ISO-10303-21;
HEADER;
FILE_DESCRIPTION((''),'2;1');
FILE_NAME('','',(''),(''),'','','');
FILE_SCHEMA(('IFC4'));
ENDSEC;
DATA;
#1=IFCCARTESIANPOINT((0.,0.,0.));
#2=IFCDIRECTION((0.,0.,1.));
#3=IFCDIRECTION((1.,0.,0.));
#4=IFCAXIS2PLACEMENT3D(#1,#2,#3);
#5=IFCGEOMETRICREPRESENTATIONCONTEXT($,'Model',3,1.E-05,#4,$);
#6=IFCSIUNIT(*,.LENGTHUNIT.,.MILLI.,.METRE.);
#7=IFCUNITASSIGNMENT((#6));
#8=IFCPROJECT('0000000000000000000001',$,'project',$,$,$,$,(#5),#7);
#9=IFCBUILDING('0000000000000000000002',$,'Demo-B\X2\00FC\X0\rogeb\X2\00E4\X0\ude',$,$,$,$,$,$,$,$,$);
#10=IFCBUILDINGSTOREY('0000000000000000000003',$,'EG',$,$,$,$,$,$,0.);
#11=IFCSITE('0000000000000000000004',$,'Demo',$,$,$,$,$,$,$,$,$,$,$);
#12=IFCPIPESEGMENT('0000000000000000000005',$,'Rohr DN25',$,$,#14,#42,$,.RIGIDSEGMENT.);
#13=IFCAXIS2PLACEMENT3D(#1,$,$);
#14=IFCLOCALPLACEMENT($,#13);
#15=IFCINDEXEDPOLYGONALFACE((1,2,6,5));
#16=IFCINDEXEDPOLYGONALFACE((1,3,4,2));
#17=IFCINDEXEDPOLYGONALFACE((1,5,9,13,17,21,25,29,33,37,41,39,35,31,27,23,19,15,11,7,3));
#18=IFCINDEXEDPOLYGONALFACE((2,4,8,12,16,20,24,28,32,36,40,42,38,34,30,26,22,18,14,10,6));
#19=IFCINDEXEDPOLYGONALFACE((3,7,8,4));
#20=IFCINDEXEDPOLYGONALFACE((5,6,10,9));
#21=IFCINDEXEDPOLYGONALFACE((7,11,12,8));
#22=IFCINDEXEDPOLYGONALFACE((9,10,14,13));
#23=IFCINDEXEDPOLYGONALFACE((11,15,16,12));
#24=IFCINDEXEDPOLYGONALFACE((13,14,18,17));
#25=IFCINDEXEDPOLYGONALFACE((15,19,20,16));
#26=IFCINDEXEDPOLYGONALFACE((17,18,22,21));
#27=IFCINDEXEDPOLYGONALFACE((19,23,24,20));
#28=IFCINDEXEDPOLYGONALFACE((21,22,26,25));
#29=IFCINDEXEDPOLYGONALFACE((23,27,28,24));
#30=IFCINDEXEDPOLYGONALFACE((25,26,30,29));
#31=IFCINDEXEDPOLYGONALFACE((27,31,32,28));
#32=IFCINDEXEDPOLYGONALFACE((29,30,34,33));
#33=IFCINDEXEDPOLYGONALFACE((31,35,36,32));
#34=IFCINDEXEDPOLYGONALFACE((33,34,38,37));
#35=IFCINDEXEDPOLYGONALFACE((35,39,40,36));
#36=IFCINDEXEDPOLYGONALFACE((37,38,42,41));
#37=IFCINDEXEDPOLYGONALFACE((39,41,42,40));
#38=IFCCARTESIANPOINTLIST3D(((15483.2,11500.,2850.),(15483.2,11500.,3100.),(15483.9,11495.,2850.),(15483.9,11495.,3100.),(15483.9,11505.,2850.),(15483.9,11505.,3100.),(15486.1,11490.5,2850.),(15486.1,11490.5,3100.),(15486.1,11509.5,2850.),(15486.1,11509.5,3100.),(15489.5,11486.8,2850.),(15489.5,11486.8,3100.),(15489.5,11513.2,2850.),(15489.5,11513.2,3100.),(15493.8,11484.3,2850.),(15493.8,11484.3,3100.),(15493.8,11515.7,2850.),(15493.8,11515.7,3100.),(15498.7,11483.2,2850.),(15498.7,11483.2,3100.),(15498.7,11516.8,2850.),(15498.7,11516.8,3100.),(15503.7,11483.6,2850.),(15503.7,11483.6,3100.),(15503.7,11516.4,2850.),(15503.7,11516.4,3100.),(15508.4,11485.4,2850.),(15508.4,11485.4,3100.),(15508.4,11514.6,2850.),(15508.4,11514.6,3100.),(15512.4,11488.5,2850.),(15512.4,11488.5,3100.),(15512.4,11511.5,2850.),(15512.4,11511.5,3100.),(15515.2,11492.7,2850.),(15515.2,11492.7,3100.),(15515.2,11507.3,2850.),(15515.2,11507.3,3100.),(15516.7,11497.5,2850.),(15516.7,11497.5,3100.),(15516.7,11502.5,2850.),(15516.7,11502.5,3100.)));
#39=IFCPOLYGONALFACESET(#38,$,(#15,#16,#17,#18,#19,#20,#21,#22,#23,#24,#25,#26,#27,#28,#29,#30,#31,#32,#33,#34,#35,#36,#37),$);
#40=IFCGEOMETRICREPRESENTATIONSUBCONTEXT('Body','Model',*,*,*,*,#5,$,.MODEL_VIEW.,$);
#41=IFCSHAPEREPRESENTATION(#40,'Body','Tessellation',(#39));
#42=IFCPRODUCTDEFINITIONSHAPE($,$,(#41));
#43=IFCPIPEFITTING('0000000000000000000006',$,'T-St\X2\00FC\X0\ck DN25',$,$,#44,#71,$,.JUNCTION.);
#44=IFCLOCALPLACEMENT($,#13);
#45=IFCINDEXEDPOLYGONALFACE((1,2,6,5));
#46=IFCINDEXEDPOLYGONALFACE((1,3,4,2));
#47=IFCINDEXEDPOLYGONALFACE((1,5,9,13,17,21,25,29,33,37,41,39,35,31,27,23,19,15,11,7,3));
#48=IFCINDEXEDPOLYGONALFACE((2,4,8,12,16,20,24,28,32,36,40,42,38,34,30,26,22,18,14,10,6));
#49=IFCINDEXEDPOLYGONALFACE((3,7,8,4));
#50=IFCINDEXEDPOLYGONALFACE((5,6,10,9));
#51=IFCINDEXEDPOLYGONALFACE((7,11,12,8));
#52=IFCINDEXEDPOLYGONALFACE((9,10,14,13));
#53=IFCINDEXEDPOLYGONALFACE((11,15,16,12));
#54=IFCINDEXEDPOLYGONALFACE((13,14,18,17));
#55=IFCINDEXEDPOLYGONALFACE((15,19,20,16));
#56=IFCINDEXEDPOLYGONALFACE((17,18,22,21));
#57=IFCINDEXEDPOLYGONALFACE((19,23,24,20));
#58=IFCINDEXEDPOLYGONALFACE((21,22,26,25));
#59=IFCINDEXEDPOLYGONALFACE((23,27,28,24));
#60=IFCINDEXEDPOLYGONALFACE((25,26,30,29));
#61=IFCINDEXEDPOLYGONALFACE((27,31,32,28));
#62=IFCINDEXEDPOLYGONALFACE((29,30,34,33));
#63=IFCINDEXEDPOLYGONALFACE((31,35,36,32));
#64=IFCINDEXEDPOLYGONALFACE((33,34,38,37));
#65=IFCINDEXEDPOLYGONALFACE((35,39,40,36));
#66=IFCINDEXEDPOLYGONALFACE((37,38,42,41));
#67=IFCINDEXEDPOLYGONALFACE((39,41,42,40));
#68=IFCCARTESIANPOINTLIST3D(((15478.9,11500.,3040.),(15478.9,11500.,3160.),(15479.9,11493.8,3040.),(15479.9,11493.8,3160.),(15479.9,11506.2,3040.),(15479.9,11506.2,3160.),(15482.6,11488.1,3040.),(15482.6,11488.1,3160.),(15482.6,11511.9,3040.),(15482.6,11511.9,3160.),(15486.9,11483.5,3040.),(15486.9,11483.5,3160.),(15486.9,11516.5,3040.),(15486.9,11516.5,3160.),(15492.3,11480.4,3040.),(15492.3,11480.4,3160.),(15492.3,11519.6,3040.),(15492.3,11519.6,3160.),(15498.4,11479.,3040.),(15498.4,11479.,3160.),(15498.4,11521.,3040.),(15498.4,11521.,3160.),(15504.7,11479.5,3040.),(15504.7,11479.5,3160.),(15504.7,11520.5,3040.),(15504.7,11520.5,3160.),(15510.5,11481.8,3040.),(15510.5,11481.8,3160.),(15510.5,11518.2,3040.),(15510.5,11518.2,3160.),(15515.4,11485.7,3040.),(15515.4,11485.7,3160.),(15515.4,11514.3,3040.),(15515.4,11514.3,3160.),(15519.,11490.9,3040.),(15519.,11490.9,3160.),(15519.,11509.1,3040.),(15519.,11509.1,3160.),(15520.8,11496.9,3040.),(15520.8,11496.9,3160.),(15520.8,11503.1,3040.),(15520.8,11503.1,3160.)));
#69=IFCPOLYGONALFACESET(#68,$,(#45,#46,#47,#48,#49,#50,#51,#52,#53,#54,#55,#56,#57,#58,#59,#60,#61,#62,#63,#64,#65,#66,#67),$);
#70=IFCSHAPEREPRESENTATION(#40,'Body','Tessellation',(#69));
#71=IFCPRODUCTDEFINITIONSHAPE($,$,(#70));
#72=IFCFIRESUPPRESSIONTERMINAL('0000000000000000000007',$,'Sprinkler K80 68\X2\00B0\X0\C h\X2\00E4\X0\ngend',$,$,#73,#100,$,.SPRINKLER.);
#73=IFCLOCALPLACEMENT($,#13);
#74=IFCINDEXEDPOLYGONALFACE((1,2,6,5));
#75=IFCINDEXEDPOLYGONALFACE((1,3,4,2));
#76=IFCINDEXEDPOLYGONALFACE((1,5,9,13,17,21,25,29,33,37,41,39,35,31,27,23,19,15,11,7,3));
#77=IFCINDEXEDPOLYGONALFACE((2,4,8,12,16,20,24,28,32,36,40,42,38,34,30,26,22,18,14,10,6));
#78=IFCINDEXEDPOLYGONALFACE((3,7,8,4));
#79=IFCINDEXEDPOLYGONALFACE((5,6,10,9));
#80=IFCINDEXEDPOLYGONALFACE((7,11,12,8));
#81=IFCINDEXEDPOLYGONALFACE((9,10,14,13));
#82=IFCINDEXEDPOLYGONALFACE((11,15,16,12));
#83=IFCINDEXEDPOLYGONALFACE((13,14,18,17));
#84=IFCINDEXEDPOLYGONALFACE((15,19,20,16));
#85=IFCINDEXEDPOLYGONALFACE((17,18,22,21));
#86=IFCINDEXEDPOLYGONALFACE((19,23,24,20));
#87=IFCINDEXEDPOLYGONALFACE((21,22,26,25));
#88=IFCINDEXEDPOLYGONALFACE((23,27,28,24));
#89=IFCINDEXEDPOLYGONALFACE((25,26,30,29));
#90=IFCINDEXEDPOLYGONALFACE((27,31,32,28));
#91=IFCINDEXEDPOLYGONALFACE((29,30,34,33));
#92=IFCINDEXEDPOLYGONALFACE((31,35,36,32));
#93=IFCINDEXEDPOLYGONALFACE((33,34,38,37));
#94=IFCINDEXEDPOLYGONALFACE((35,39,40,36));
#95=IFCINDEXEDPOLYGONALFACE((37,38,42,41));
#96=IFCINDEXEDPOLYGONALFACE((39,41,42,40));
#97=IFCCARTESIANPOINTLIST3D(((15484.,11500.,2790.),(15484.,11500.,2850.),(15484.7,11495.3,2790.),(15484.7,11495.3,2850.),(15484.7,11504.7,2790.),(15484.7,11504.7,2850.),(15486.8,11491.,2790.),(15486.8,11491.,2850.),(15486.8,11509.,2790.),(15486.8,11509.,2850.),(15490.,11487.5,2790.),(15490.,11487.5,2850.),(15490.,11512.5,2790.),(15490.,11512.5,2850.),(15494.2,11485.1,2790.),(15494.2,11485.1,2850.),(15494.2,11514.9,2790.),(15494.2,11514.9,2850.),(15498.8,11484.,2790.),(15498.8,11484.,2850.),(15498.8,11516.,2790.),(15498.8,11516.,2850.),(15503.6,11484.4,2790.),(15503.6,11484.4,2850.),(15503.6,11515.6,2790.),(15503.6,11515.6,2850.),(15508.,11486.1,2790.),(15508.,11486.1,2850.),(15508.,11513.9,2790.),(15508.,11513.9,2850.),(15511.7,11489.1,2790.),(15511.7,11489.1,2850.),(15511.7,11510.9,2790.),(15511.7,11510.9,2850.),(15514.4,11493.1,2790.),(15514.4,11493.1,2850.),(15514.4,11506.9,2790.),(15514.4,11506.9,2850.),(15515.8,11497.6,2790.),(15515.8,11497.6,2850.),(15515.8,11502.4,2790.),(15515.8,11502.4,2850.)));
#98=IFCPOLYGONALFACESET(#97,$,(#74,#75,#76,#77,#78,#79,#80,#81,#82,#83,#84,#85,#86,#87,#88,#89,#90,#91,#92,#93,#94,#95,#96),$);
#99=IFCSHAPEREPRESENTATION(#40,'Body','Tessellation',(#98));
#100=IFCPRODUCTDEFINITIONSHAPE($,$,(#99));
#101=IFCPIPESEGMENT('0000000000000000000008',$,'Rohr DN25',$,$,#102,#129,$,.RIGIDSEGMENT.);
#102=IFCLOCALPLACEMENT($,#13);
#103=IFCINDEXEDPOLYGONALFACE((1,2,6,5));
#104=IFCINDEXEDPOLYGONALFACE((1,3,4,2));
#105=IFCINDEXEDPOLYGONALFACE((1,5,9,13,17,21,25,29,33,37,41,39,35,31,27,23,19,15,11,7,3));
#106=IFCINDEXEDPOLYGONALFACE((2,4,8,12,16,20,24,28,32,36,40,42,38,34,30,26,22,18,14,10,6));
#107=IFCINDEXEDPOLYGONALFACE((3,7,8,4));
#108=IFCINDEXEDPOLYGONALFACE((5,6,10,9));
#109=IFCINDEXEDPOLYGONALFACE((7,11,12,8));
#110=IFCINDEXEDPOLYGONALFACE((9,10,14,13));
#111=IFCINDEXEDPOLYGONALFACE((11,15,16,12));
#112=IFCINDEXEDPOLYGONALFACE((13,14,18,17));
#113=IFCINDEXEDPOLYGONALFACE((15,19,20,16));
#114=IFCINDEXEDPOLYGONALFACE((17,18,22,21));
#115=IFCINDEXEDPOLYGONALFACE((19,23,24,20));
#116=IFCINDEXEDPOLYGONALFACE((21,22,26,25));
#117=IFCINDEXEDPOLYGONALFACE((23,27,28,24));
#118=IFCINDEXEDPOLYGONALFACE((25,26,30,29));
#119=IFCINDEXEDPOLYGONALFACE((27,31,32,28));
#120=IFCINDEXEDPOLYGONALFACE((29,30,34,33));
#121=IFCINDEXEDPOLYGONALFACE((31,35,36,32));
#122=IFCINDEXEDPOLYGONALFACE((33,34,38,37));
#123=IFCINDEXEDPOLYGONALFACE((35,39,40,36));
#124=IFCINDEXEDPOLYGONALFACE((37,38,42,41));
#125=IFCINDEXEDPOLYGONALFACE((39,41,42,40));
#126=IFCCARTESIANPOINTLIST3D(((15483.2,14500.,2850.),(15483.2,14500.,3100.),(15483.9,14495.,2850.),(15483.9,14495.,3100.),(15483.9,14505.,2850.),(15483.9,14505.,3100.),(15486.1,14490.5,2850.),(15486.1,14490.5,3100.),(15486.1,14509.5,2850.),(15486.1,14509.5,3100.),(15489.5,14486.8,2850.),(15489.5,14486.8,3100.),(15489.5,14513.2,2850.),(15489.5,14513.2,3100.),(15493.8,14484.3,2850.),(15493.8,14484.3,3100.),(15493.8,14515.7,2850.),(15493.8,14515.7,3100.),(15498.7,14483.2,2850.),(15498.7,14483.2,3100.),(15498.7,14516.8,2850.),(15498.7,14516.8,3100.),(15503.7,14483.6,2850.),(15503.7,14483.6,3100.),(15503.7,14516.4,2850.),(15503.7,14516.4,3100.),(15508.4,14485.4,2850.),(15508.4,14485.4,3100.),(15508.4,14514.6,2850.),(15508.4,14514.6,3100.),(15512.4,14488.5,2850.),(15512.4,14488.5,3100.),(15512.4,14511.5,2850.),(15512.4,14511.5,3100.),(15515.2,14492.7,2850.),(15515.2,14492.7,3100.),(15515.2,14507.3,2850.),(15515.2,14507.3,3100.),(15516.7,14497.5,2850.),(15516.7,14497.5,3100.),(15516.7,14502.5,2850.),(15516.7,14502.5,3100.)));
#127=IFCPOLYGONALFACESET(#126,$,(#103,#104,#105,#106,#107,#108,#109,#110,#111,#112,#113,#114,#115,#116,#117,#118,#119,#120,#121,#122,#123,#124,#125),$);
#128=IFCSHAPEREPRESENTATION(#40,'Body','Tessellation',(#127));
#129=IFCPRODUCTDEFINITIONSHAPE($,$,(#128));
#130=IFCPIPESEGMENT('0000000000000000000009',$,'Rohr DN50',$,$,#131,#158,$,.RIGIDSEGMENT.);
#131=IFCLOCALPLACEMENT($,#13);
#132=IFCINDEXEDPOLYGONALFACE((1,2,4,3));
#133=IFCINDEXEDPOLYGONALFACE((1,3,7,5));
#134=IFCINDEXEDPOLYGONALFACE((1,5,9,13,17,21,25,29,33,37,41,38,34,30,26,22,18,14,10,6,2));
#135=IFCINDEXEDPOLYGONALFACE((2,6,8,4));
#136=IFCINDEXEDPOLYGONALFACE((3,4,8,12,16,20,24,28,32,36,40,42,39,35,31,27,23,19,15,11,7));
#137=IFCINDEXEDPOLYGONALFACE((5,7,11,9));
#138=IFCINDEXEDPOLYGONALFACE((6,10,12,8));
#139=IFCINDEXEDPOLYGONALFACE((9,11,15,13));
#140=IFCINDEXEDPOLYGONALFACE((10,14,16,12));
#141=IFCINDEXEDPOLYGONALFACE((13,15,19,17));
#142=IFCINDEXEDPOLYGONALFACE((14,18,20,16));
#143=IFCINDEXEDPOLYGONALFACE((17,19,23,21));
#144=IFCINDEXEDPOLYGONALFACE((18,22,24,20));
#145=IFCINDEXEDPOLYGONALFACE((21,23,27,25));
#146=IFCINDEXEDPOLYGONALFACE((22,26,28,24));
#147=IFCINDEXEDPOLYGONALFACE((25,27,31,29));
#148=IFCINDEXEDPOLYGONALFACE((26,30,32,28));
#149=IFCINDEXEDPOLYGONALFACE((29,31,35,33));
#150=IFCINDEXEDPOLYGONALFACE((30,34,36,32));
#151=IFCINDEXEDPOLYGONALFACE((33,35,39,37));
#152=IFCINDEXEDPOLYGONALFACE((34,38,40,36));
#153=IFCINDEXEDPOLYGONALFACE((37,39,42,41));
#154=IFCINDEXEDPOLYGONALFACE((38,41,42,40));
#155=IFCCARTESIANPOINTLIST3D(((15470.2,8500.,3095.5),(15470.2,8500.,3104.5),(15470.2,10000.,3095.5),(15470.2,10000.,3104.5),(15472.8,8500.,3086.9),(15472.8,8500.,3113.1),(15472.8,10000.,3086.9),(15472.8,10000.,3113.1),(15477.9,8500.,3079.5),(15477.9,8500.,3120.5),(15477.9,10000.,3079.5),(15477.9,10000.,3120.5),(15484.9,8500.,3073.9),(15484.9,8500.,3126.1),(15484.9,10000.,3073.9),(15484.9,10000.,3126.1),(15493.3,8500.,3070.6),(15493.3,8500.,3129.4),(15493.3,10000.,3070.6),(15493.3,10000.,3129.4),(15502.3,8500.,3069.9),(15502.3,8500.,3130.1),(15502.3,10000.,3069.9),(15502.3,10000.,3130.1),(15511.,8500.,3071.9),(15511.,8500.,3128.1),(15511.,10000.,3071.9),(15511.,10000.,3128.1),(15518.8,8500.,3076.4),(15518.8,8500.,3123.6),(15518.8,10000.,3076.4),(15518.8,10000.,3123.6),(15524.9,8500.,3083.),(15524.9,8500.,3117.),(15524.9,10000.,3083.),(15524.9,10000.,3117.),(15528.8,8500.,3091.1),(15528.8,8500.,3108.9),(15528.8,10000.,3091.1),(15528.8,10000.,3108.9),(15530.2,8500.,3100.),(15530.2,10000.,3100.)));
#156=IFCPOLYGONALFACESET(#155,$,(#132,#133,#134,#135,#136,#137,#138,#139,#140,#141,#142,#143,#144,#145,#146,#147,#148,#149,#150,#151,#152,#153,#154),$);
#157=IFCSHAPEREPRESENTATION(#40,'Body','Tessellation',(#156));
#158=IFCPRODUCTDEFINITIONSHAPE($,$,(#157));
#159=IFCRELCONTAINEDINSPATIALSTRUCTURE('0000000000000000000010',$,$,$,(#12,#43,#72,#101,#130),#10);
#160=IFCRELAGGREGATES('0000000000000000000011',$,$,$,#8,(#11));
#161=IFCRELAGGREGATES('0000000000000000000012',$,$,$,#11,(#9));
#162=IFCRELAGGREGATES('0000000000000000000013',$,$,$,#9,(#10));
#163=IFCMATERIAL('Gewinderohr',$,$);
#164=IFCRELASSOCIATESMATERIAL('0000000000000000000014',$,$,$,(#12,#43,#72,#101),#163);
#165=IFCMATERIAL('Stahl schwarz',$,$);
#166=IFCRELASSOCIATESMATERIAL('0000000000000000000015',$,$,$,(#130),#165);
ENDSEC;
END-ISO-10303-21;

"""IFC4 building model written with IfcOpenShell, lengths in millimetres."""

from ifc_helpers import new_model, si_unit, frame, origin_with_axes, place, context, subcontext, project, spatial, circle, extrude, material, element, save


model = new_model("IFC4")

# Units and contexts
model_context = context("Model", 3, precision=1e-05, world=origin_with_axes())
body_context = subcontext(model_context, "Body", "Model", "MODEL_VIEW")
ifc_project = project(units=[si_unit("LENGTHUNIT", "METRE", prefix="MILLI")], contexts=[model_context])

# Site, building, storey
site = spatial("IfcSite", under=ifc_project, Name="Demo")
building = spatial("IfcBuilding", under=site, Name="Demo-Bürogebäude")
storey = spatial("IfcBuildingStorey", under=building, Name="EG", Elevation=0.0)

# Shared definitions
ifc_material_1 = material(Name="Stahl schwarz")

# Shared definitions
ifc_material_2 = material(Name="Gewinderohr")

# Pipe segment
pipe_segment_1_placement = place(None, frame((15500.0, 11500.0, 3100.0), z_axis=(0.0, 0.0, -1.0), x_axis=(-1.0, 0.0, 0.0)))
element("IfcPipeSegment", 1, at=pipe_segment_1_placement, inside=storey, material=ifc_material_2, Name="Rohr DN25", PredefinedType="RIGIDSEGMENT", context=body_context, shape_type="SweptSolid", body=[
    extrude(circle(Radius=16.9), origin_with_axes(), (0.0, 0.0, 1.0), 250.0),
])

# Pipe fitting
pipe_fitting_1_placement = place(None, frame((15500.0, 11500.0, 3160.0), z_axis=(0.0, 0.0, -1.0), x_axis=(-1.0, 0.0, 0.0)))
element("IfcPipeFitting", 2, at=pipe_fitting_1_placement, inside=storey, material=ifc_material_2, Name="T-Stück DN25", PredefinedType="JUNCTION", context=body_context, shape_type="SweptSolid", body=[
    extrude(circle(Radius=21.1), origin_with_axes(), (0.0, 0.0, 1.0), 120.0),
])

# Fire suppression terminal
fire_suppression_terminal_1_placement = place(None, frame((15500.0, 11500.0, 2850.0), z_axis=(0.0, 0.0, -1.0), x_axis=(-1.0, 0.0, 0.0)))
element("IfcFireSuppressionTerminal", 3, at=fire_suppression_terminal_1_placement, inside=storey, material=ifc_material_2, Name="Sprinkler K80 68°C hängend", PredefinedType="SPRINKLER", context=body_context, shape_type="SweptSolid", body=[
    extrude(circle(Radius=16.0), origin_with_axes(), (0.0, 0.0, 1.0), 60.0),
])

# Pipe segments
pipe_segment_2_placement = place(None, frame((15500.0, 14500.0, 3100.0), z_axis=(0.0, 0.0, -1.0), x_axis=(-1.0, 0.0, 0.0)))
element("IfcPipeSegment", 4, at=pipe_segment_2_placement, inside=storey, material=ifc_material_2, Name="Rohr DN25", PredefinedType="RIGIDSEGMENT", context=body_context, shape_type="SweptSolid", body=[
    extrude(circle(Radius=16.9), origin_with_axes(), (0.0, 0.0, 1.0), 250.0),
])
pipe_segment_3_placement = place(None, frame((15500.0, 10000.0, 3100.0), z_axis=(0.0, -1.0, 0.0), x_axis=(1.0, 0.0, 0.0)))
element("IfcPipeSegment", 5, at=pipe_segment_3_placement, inside=storey, material=ifc_material_1, Name="Rohr DN50", PredefinedType="RIGIDSEGMENT", context=body_context, shape_type="SweptSolid", body=[
    extrude(circle(Radius=30.1), origin_with_axes(), (0.0, 0.0, 1.0), 1500.0),
])

save(model, "model.ifc")
